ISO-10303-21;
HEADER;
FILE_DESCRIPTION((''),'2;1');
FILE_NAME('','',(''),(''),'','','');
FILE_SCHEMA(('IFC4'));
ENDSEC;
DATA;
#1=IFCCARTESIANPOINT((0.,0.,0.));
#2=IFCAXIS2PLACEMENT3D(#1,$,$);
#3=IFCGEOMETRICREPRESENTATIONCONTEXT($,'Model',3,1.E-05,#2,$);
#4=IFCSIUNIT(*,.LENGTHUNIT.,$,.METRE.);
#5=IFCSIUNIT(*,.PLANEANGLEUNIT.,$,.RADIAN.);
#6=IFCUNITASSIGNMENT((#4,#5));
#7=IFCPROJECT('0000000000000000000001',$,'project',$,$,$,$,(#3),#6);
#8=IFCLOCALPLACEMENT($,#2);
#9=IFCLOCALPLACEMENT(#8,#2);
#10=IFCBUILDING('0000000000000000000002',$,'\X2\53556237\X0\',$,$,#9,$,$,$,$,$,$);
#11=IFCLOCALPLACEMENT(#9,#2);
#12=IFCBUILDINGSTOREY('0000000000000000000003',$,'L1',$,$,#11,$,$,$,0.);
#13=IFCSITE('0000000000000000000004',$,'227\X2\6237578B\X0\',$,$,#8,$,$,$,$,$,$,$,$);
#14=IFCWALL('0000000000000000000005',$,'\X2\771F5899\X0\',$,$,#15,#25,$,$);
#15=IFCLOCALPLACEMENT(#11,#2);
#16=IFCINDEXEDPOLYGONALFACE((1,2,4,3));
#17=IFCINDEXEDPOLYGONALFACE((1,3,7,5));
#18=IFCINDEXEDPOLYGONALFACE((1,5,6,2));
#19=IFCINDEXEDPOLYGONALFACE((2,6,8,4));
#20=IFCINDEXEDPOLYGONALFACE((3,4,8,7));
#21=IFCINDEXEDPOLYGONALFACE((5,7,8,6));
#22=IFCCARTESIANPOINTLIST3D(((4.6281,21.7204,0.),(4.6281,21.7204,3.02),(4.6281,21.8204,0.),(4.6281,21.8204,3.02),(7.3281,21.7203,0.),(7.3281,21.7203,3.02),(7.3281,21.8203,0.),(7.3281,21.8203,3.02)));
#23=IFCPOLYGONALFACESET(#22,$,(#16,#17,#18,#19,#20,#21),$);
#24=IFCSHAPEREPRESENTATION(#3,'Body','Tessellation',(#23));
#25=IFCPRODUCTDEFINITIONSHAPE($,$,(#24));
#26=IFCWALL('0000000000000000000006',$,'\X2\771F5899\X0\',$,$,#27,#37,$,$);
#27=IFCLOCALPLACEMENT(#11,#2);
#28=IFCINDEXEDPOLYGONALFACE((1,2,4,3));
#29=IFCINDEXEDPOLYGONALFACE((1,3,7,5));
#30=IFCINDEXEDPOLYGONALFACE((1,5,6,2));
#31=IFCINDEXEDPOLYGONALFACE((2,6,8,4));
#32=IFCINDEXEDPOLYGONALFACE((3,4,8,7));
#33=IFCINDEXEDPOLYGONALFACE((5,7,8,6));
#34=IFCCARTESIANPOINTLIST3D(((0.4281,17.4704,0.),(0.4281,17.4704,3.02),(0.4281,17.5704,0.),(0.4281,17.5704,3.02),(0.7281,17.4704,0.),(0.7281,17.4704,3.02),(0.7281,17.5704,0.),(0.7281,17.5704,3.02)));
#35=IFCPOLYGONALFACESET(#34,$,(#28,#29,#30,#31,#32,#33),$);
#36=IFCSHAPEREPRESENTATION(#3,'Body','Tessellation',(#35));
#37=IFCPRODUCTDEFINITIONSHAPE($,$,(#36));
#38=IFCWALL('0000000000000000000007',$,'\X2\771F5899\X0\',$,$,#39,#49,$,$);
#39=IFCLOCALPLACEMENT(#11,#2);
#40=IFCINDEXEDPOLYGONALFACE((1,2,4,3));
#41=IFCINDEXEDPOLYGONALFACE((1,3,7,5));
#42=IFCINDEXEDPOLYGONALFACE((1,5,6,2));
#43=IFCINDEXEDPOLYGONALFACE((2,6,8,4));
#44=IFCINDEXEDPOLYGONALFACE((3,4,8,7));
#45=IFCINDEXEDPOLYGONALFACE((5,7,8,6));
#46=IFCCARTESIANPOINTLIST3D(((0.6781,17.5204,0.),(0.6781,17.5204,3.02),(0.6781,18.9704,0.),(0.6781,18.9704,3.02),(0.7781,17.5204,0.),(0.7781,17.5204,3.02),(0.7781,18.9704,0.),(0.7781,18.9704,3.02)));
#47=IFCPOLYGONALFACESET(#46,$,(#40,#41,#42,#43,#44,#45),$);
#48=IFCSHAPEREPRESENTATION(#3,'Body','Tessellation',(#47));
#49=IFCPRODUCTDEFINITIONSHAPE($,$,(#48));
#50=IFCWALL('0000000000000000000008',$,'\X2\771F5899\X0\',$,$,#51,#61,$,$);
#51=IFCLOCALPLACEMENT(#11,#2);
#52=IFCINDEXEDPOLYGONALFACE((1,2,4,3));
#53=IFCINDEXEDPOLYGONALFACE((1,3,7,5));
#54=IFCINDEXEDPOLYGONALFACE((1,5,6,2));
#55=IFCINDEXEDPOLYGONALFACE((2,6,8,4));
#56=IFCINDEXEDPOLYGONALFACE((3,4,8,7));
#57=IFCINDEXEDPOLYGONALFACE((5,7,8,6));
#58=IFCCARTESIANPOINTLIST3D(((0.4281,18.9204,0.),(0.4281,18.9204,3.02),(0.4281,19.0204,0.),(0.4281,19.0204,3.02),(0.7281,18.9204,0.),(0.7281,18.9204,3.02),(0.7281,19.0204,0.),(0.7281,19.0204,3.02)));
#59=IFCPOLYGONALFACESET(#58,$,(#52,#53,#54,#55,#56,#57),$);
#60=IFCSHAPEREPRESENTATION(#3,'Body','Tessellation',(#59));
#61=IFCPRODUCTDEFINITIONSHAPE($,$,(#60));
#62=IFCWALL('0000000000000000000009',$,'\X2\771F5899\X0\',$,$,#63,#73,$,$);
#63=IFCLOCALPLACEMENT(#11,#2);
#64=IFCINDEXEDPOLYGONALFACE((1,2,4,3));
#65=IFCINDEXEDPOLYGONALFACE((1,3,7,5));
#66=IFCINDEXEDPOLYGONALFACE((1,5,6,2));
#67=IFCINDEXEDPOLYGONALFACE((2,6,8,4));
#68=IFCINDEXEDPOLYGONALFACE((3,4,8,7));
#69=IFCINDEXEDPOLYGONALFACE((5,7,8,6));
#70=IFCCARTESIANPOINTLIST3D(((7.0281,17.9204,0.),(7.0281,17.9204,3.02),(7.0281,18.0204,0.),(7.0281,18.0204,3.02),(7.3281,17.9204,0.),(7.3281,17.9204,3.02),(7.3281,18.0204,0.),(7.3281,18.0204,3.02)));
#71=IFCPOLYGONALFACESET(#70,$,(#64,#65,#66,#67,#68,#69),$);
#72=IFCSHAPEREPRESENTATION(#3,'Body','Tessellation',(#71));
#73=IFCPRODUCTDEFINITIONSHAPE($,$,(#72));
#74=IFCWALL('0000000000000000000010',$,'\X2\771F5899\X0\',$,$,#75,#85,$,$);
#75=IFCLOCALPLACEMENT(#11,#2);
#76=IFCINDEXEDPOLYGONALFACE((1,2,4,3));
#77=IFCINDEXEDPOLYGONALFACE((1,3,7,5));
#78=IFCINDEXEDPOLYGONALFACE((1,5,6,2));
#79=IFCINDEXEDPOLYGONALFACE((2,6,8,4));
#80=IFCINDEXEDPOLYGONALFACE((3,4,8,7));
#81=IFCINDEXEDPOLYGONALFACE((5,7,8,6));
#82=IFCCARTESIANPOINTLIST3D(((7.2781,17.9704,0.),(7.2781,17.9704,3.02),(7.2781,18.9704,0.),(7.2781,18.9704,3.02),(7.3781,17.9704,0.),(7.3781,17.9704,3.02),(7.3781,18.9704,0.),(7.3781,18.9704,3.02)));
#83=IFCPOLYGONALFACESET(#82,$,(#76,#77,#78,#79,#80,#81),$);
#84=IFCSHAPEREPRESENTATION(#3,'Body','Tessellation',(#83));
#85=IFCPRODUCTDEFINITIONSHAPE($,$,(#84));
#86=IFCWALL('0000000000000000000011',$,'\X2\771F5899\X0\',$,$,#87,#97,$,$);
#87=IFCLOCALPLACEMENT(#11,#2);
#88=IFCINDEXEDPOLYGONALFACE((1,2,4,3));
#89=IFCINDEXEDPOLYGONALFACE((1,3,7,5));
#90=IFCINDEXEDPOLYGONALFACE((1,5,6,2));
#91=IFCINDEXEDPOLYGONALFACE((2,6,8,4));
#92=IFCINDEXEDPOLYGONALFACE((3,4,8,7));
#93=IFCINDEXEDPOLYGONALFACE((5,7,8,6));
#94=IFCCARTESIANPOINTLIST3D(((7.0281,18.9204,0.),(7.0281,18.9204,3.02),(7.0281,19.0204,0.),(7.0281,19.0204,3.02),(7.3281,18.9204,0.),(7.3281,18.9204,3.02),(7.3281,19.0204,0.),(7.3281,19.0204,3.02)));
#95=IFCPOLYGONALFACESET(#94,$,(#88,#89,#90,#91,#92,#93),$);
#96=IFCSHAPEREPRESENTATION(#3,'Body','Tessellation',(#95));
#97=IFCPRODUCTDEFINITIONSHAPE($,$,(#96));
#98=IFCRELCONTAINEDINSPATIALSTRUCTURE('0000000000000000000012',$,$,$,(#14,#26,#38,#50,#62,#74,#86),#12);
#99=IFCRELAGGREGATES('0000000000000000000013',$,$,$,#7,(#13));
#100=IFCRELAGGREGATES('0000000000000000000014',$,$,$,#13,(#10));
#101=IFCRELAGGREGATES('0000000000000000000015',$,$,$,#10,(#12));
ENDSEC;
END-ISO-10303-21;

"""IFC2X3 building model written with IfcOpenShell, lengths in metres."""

from ifc_helpers import new_model, si_unit, origin, place, context, project, spatial, polyline, outline, extrude, element, save


model = new_model("IFC2X3")

# Units and contexts
model_context = context("Model", 3, precision=1e-05, world=origin())
ifc_project = project(units=[si_unit("LENGTHUNIT", "METRE"), si_unit("PLANEANGLEUNIT", "RADIAN")], contexts=[model_context])

# Site, building, storey
site_placement = place(None, origin())
site = spatial("IfcSite", under=ifc_project, at=site_placement, Name="227户型")
building_placement = place(site_placement, origin())
building = spatial("IfcBuilding", under=site, at=building_placement, Name="单户")
storey_placement = place(building_placement, origin())
storey = spatial("IfcBuildingStorey", under=building, at=storey_placement, Name="L1", Elevation=0.0)

# Wall
wall_1_placement = place(storey_placement, origin())
element("IfcWall", 1, at=wall_1_placement, inside=storey, Name="真墙", context=model_context, shape_type="SweptSolid", body=[
    extrude(outline(polyline([(4.6281, 21.8204), (7.3281, 21.8203), (7.3281, 21.7203), (4.6281, 21.7204), (4.6281, 21.8204)])), origin(), (0.0, 0.0, 1.0), 3.02),
])

# Walls
wall_2_placement = place(storey_placement, origin())
element("IfcWall", 2, at=wall_2_placement, inside=storey, Name="真墙", context=model_context, shape_type="SweptSolid", body=[
    extrude(outline(polyline([(0.4281, 17.5704), (0.7281, 17.5704), (0.7281, 17.4704), (0.4281, 17.4704), (0.4281, 17.5704)])), origin(), (0.0, 0.0, 1.0), 3.02),
])
wall_3_placement = place(storey_placement, origin())
element("IfcWall", 3, at=wall_3_placement, inside=storey, Name="真墙", context=model_context, shape_type="SweptSolid", body=[
    extrude(outline(polyline([(0.6781, 17.5204), (0.6781, 18.9704), (0.7781, 18.9704), (0.7781, 17.5204), (0.6781, 17.5204)])), origin(), (0.0, 0.0, 1.0), 3.02),
])
wall_4_placement = place(storey_placement, origin())
element("IfcWall", 4, at=wall_4_placement, inside=storey, Name="真墙", context=model_context, shape_type="SweptSolid", body=[
    extrude(outline(polyline([(0.7281, 18.9204), (0.4281, 18.9204), (0.4281, 19.0204), (0.7281, 19.0204), (0.7281, 18.9204)])), origin(), (0.0, 0.0, 1.0), 3.02),
])
wall_5_placement = place(storey_placement, origin())
element("IfcWall", 5, at=wall_5_placement, inside=storey, Name="真墙", context=model_context, shape_type="SweptSolid", body=[
    extrude(outline(polyline([(7.0281, 18.0204), (7.3281, 18.0204), (7.3281, 17.9204), (7.0281, 17.9204), (7.0281, 18.0204)])), origin(), (0.0, 0.0, 1.0), 3.02),
])
wall_6_placement = place(storey_placement, origin())
element("IfcWall", 6, at=wall_6_placement, inside=storey, Name="真墙", context=model_context, shape_type="SweptSolid", body=[
    extrude(outline(polyline([(7.2781, 17.9704), (7.2781, 18.9704), (7.3781, 18.9704), (7.3781, 17.9704), (7.2781, 17.9704)])), origin(), (0.0, 0.0, 1.0), 3.02),
])
wall_7_placement = place(storey_placement, origin())
element("IfcWall", 7, at=wall_7_placement, inside=storey, Name="真墙", context=model_context, shape_type="SweptSolid", body=[
    extrude(outline(polyline([(7.3281, 18.9204), (7.0281, 18.9204), (7.0281, 19.0204), (7.3281, 19.0204), (7.3281, 18.9204)])), origin(), (0.0, 0.0, 1.0), 3.02),
])

save(model, "model.ifc")
